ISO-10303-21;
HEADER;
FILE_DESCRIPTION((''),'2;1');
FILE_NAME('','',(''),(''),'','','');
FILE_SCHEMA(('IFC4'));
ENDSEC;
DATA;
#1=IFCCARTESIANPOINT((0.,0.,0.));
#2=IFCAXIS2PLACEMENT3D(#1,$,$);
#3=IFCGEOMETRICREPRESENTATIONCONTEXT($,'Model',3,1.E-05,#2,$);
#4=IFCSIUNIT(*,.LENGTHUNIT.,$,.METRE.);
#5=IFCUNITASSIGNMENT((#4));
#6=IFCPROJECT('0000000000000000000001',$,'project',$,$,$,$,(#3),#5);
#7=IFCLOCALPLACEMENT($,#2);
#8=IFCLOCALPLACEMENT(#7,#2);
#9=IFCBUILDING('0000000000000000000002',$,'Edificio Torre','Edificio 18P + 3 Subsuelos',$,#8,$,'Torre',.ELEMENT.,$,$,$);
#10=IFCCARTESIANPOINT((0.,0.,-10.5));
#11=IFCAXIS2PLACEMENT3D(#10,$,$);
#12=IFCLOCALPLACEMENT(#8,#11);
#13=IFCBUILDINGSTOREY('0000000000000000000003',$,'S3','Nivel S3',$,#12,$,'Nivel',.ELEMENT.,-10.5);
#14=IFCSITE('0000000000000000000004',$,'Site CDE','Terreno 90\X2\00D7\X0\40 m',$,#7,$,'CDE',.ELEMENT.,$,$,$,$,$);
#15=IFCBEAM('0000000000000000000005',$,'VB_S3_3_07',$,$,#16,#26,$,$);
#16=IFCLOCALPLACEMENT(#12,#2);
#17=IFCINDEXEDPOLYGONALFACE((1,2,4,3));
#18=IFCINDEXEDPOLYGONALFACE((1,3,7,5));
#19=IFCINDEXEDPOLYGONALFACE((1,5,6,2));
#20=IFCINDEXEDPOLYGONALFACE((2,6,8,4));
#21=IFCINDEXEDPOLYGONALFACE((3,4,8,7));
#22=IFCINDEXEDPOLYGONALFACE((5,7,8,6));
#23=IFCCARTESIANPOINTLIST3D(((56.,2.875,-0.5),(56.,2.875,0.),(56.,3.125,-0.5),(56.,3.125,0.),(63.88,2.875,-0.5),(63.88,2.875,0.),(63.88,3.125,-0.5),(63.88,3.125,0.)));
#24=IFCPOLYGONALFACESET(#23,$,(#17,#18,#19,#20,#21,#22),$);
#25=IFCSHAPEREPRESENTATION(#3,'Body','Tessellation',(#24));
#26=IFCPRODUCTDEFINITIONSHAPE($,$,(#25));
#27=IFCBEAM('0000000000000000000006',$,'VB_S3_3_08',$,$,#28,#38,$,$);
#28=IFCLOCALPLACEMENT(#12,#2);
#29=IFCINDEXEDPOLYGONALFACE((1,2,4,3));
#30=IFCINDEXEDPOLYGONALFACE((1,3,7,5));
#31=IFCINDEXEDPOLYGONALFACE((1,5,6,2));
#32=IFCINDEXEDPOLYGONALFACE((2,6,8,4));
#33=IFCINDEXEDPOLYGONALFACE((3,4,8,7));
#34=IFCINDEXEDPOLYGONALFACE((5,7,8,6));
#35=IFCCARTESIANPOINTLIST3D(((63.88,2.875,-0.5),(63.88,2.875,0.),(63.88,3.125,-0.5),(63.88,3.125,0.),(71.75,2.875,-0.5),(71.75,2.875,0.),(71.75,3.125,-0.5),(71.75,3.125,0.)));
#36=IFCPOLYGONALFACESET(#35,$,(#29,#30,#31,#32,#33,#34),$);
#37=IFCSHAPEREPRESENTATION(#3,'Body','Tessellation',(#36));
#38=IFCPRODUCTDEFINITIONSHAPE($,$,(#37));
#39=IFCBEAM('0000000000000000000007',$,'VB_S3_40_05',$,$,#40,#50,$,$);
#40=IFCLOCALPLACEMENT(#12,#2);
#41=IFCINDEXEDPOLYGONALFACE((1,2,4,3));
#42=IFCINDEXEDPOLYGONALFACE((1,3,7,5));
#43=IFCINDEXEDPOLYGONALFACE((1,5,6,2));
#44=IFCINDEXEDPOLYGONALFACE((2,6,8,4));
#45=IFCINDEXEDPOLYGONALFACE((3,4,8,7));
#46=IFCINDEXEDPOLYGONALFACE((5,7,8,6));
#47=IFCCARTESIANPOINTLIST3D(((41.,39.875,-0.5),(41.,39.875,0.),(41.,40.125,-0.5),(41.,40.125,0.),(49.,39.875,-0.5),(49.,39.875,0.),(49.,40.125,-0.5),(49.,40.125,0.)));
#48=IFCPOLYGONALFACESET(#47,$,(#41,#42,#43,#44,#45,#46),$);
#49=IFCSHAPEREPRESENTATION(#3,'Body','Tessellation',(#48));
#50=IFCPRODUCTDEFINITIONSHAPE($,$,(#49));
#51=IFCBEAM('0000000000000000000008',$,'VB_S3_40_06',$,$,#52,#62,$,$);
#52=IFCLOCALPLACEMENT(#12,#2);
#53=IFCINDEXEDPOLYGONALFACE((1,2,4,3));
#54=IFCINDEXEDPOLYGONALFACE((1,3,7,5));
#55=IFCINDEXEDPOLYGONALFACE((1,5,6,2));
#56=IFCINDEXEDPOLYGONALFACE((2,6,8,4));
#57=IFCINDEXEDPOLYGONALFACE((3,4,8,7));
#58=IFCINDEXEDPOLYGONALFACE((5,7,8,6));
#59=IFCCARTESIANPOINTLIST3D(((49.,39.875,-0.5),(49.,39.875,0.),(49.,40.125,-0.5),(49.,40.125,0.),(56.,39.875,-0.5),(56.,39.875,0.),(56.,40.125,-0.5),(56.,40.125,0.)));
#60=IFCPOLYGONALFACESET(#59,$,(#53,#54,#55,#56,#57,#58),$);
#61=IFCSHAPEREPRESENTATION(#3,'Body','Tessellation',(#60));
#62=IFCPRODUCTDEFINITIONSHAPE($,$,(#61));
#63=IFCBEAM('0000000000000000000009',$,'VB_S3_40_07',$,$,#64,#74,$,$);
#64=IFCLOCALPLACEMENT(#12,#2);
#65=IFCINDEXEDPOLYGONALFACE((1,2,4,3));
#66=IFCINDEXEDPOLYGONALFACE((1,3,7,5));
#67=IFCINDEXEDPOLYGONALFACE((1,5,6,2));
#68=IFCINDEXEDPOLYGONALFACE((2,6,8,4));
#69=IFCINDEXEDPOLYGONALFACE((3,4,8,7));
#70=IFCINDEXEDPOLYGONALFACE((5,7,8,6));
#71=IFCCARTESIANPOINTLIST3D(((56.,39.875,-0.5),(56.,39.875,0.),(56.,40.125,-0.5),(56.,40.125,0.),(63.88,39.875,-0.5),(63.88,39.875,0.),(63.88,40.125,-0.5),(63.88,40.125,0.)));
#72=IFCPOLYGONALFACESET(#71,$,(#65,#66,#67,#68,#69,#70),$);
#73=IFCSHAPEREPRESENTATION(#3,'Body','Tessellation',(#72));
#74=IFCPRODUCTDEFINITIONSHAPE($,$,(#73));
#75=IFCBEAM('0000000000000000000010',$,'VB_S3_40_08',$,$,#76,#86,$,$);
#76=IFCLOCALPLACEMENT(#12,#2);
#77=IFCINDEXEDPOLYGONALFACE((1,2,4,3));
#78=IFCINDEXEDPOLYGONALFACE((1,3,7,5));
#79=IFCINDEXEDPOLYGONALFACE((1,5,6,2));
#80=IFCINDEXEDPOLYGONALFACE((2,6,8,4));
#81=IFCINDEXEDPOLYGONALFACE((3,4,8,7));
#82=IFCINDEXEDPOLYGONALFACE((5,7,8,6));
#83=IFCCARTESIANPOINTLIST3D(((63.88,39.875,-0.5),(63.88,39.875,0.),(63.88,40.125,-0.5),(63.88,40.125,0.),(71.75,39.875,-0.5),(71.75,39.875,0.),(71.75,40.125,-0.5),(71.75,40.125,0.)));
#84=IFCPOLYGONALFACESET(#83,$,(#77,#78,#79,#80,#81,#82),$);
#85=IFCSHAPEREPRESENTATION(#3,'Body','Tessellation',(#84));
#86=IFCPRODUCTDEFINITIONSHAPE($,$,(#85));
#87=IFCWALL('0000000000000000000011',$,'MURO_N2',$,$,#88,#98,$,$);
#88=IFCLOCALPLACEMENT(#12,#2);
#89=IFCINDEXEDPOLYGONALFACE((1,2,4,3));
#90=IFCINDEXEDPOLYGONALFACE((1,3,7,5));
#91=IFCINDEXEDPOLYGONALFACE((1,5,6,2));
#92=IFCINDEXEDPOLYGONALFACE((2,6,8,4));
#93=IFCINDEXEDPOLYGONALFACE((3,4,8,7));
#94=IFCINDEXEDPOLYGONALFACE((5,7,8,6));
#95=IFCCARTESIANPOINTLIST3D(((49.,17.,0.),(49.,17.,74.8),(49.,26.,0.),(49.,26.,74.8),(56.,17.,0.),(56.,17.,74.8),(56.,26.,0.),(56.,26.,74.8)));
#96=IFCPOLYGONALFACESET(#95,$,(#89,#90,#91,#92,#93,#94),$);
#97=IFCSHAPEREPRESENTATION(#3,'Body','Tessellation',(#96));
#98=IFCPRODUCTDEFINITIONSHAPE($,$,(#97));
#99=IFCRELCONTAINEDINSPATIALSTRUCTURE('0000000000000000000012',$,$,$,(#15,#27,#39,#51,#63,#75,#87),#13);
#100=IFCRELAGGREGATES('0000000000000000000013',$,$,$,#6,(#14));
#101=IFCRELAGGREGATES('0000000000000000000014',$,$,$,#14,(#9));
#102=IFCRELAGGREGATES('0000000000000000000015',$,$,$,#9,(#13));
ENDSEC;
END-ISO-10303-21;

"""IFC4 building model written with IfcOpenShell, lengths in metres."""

from ifc_helpers import new_model, si_unit, frame, origin, origin_2d, place, context, project, spatial, rectangle, extrude, element, save


model = new_model("IFC4")

# Units and contexts
model_context = context("Model", 3, precision=1e-05, world=origin())
ifc_project = project(units=[si_unit("LENGTHUNIT", "METRE")], contexts=[model_context])

# Site, building, storey
site_placement = place(None, origin())
site = spatial("IfcSite", under=ifc_project, at=site_placement, Name="Site CDE", Description="Terreno 90×40 m", LongName="CDE", CompositionType="ELEMENT")
building_placement = place(site_placement, origin())
building = spatial("IfcBuilding", under=site, at=building_placement, Name="Edificio Torre", Description="Edificio 18P + 3 Subsuelos", LongName="Torre", CompositionType="ELEMENT")
storey_placement = place(building_placement, frame((0.0, 0.0, -10.5)))
storey = spatial("IfcBuildingStorey", under=building, at=storey_placement, Name="S3", Description="Nivel S3", LongName="Nivel", CompositionType="ELEMENT", Elevation=-10.5)

# Beams
beam_1_placement = place(storey_placement, frame((59.94, 3.0, -0.5)))
element("IfcBeam", 1, at=beam_1_placement, inside=storey, Name="VB_S3_3_07", context=model_context, shape_type="SweptSolid", body=[
    extrude(rectangle(XDim=7.88, YDim=0.25, at=origin_2d()), origin(), (0.0, 0.0, 1.0), 0.5),
])
beam_2_placement = place(storey_placement, frame((67.815, 3.0, -0.5)))
element("IfcBeam", 2, at=beam_2_placement, inside=storey, Name="VB_S3_3_08", context=model_context, shape_type="SweptSolid", body=[
    extrude(rectangle(XDim=7.87, YDim=0.25, at=origin_2d()), origin(), (0.0, 0.0, 1.0), 0.5),
])
beam_3_placement = place(storey_placement, frame((45.0, 40.0, -0.5)))
element("IfcBeam", 3, at=beam_3_placement, inside=storey, Name="VB_S3_40_05", context=model_context, shape_type="SweptSolid", body=[
    extrude(rectangle(XDim=8.0, YDim=0.25, at=origin_2d()), origin(), (0.0, 0.0, 1.0), 0.5),
])
beam_4_placement = place(storey_placement, frame((52.5, 40.0, -0.5)))
element("IfcBeam", 4, at=beam_4_placement, inside=storey, Name="VB_S3_40_06", context=model_context, shape_type="SweptSolid", body=[
    extrude(rectangle(XDim=7.0, YDim=0.25, at=origin_2d()), origin(), (0.0, 0.0, 1.0), 0.5),
])
beam_5_placement = place(storey_placement, frame((59.94, 40.0, -0.5)))
element("IfcBeam", 5, at=beam_5_placement, inside=storey, Name="VB_S3_40_07", context=model_context, shape_type="SweptSolid", body=[
    extrude(rectangle(XDim=7.88, YDim=0.25, at=origin_2d()), origin(), (0.0, 0.0, 1.0), 0.5),
])
beam_6_placement = place(storey_placement, frame((67.815, 40.0, -0.5)))
element("IfcBeam", 6, at=beam_6_placement, inside=storey, Name="VB_S3_40_08", context=model_context, shape_type="SweptSolid", body=[
    extrude(rectangle(XDim=7.87, YDim=0.25, at=origin_2d()), origin(), (0.0, 0.0, 1.0), 0.5),
])

# Wall
wall_placement = place(storey_placement, frame((52.5, 21.5, 0.0)))
element("IfcWall", 7, at=wall_placement, inside=storey, Name="MURO_N2", context=model_context, shape_type="SweptSolid", body=[
    extrude(rectangle(XDim=7.0, YDim=9.0, at=origin_2d()), origin(), (0.0, 0.0, 1.0), 74.8),
])

save(model, "model.ifc")
